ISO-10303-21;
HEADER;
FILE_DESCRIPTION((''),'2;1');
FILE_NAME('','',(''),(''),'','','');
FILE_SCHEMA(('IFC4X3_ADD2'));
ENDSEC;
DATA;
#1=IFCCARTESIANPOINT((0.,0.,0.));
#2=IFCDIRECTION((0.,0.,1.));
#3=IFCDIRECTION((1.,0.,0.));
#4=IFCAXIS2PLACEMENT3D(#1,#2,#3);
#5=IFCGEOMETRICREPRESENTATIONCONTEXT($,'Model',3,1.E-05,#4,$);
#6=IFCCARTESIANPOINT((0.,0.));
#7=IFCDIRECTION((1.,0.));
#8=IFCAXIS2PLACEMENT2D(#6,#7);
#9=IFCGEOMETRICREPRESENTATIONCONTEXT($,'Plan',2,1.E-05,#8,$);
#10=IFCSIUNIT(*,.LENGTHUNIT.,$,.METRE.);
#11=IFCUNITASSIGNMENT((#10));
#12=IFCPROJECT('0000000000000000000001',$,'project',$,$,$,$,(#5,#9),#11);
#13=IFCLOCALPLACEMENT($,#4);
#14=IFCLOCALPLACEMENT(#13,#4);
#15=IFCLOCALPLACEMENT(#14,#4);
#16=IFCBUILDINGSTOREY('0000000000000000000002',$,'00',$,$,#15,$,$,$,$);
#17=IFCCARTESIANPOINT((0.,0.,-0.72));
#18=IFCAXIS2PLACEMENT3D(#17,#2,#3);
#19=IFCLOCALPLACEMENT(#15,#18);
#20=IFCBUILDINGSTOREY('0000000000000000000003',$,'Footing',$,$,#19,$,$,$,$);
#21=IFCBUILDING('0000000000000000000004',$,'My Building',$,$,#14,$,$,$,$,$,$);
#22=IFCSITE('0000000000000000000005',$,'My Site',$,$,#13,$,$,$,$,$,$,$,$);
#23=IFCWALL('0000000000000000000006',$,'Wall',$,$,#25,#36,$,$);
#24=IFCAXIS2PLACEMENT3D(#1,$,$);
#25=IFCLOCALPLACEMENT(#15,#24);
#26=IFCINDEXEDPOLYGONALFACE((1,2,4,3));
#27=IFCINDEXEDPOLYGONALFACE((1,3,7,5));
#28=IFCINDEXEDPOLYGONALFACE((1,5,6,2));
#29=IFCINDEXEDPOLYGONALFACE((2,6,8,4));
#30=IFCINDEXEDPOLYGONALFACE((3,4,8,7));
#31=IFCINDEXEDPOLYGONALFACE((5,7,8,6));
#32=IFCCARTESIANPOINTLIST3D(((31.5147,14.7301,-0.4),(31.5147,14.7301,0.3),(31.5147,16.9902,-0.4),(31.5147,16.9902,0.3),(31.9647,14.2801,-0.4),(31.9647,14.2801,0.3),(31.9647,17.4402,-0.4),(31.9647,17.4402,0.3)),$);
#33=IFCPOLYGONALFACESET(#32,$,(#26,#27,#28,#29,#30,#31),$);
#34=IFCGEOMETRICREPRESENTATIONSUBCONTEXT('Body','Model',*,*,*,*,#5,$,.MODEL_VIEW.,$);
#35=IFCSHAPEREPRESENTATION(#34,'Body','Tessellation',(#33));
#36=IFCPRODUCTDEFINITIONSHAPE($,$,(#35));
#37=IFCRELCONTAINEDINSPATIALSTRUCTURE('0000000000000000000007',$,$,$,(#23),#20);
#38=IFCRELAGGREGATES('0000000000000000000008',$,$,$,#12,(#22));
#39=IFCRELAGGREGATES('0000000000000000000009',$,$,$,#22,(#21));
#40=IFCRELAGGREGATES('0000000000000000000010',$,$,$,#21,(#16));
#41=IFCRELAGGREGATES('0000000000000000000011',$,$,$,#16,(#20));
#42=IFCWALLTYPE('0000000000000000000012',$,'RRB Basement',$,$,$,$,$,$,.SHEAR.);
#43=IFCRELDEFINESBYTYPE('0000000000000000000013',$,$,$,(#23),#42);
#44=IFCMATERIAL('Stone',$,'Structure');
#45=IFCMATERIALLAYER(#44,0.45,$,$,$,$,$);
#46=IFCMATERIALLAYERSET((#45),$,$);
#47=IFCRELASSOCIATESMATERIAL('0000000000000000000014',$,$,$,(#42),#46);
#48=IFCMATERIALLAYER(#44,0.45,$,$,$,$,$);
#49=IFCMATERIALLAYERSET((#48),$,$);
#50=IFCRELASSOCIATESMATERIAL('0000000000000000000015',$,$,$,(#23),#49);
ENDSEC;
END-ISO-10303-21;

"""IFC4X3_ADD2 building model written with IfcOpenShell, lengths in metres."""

from ifc_helpers import new_model, si_unit, frame, origin_with_axes, origin_2d_with_axis, place, context, subcontext, project, spatial, line, indexed_curve, outline, extrude, material, layer, layer_set, layer_usage, type_object, element, save


model = new_model("IFC4X3_ADD2")

# Units and contexts
model_context = context("Model", 3, precision=1e-05, world=origin_with_axes())
plan_context = context("Plan", 2, precision=1e-05, world=origin_2d_with_axis())
body_context = subcontext(model_context, "Body", "Model", "MODEL_VIEW")
ifc_project = project(units=[si_unit("LENGTHUNIT", "METRE")], contexts=[model_context, plan_context])

# Site, building, storeys
site_placement = place(None, origin_with_axes())
site = spatial("IfcSite", under=ifc_project, at=site_placement, Name="My Site")
building_placement = place(site_placement, origin_with_axes())
building = spatial("IfcBuilding", under=site, at=building_placement, Name="My Building")
storey_1_placement = place(building_placement, origin_with_axes())
storey_1 = spatial("IfcBuildingStorey", under=building, at=storey_1_placement, Name="00")
storey_2_placement = place(storey_1_placement, frame((0.0, 0.0, -0.72), z_axis=(0.0, 0.0, 1.0), x_axis=(1.0, 0.0, 0.0)))
storey_2 = spatial("IfcBuildingStorey", under=storey_1, at=storey_2_placement, Name="Footing")

# Wall
ifc_material_1 = material(Name="Stone", Category="Structure")
ifc_layer_1 = layer(ifc_material_1, 0.45)
ifc_layer_set_1 = layer_set([ifc_layer_1])
wall_type_1 = type_object("IfcWallType", Name="RRB Basement", PredefinedType="SHEAR", material=ifc_layer_set_1)
ifc_layer_2 = layer(ifc_material_1, 0.45)
ifc_layer_set_2 = layer_set([ifc_layer_2])
ifc_layer_usage_1 = layer_usage(ifc_layer_set_2, "AXIS2", "NEGATIVE", 0.0)
wall_1_placement = place(storey_2_placement, frame((31.5147, 14.2801, 0.32), z_axis=(0.0, 0.0, 1.0), x_axis=(0.0, 1.0, 0.0)))
element("IfcWall", 1, at=wall_1_placement, inside=storey_2, type_object=wall_type_1, material=ifc_layer_usage_1, Name="Wall", context=body_context, shape_type="SweptSolid", body=[
    extrude(outline(indexed_curve([(0.0, -0.45), (0.45, 0.0), (2.71, 0.0), (3.16, -0.45)], segments=[line(1, 2, 3, 4, 1)])), origin_with_axes(), (0.0, 0.0, 1.0), 0.7),
])

save(model, "model.ifc")
